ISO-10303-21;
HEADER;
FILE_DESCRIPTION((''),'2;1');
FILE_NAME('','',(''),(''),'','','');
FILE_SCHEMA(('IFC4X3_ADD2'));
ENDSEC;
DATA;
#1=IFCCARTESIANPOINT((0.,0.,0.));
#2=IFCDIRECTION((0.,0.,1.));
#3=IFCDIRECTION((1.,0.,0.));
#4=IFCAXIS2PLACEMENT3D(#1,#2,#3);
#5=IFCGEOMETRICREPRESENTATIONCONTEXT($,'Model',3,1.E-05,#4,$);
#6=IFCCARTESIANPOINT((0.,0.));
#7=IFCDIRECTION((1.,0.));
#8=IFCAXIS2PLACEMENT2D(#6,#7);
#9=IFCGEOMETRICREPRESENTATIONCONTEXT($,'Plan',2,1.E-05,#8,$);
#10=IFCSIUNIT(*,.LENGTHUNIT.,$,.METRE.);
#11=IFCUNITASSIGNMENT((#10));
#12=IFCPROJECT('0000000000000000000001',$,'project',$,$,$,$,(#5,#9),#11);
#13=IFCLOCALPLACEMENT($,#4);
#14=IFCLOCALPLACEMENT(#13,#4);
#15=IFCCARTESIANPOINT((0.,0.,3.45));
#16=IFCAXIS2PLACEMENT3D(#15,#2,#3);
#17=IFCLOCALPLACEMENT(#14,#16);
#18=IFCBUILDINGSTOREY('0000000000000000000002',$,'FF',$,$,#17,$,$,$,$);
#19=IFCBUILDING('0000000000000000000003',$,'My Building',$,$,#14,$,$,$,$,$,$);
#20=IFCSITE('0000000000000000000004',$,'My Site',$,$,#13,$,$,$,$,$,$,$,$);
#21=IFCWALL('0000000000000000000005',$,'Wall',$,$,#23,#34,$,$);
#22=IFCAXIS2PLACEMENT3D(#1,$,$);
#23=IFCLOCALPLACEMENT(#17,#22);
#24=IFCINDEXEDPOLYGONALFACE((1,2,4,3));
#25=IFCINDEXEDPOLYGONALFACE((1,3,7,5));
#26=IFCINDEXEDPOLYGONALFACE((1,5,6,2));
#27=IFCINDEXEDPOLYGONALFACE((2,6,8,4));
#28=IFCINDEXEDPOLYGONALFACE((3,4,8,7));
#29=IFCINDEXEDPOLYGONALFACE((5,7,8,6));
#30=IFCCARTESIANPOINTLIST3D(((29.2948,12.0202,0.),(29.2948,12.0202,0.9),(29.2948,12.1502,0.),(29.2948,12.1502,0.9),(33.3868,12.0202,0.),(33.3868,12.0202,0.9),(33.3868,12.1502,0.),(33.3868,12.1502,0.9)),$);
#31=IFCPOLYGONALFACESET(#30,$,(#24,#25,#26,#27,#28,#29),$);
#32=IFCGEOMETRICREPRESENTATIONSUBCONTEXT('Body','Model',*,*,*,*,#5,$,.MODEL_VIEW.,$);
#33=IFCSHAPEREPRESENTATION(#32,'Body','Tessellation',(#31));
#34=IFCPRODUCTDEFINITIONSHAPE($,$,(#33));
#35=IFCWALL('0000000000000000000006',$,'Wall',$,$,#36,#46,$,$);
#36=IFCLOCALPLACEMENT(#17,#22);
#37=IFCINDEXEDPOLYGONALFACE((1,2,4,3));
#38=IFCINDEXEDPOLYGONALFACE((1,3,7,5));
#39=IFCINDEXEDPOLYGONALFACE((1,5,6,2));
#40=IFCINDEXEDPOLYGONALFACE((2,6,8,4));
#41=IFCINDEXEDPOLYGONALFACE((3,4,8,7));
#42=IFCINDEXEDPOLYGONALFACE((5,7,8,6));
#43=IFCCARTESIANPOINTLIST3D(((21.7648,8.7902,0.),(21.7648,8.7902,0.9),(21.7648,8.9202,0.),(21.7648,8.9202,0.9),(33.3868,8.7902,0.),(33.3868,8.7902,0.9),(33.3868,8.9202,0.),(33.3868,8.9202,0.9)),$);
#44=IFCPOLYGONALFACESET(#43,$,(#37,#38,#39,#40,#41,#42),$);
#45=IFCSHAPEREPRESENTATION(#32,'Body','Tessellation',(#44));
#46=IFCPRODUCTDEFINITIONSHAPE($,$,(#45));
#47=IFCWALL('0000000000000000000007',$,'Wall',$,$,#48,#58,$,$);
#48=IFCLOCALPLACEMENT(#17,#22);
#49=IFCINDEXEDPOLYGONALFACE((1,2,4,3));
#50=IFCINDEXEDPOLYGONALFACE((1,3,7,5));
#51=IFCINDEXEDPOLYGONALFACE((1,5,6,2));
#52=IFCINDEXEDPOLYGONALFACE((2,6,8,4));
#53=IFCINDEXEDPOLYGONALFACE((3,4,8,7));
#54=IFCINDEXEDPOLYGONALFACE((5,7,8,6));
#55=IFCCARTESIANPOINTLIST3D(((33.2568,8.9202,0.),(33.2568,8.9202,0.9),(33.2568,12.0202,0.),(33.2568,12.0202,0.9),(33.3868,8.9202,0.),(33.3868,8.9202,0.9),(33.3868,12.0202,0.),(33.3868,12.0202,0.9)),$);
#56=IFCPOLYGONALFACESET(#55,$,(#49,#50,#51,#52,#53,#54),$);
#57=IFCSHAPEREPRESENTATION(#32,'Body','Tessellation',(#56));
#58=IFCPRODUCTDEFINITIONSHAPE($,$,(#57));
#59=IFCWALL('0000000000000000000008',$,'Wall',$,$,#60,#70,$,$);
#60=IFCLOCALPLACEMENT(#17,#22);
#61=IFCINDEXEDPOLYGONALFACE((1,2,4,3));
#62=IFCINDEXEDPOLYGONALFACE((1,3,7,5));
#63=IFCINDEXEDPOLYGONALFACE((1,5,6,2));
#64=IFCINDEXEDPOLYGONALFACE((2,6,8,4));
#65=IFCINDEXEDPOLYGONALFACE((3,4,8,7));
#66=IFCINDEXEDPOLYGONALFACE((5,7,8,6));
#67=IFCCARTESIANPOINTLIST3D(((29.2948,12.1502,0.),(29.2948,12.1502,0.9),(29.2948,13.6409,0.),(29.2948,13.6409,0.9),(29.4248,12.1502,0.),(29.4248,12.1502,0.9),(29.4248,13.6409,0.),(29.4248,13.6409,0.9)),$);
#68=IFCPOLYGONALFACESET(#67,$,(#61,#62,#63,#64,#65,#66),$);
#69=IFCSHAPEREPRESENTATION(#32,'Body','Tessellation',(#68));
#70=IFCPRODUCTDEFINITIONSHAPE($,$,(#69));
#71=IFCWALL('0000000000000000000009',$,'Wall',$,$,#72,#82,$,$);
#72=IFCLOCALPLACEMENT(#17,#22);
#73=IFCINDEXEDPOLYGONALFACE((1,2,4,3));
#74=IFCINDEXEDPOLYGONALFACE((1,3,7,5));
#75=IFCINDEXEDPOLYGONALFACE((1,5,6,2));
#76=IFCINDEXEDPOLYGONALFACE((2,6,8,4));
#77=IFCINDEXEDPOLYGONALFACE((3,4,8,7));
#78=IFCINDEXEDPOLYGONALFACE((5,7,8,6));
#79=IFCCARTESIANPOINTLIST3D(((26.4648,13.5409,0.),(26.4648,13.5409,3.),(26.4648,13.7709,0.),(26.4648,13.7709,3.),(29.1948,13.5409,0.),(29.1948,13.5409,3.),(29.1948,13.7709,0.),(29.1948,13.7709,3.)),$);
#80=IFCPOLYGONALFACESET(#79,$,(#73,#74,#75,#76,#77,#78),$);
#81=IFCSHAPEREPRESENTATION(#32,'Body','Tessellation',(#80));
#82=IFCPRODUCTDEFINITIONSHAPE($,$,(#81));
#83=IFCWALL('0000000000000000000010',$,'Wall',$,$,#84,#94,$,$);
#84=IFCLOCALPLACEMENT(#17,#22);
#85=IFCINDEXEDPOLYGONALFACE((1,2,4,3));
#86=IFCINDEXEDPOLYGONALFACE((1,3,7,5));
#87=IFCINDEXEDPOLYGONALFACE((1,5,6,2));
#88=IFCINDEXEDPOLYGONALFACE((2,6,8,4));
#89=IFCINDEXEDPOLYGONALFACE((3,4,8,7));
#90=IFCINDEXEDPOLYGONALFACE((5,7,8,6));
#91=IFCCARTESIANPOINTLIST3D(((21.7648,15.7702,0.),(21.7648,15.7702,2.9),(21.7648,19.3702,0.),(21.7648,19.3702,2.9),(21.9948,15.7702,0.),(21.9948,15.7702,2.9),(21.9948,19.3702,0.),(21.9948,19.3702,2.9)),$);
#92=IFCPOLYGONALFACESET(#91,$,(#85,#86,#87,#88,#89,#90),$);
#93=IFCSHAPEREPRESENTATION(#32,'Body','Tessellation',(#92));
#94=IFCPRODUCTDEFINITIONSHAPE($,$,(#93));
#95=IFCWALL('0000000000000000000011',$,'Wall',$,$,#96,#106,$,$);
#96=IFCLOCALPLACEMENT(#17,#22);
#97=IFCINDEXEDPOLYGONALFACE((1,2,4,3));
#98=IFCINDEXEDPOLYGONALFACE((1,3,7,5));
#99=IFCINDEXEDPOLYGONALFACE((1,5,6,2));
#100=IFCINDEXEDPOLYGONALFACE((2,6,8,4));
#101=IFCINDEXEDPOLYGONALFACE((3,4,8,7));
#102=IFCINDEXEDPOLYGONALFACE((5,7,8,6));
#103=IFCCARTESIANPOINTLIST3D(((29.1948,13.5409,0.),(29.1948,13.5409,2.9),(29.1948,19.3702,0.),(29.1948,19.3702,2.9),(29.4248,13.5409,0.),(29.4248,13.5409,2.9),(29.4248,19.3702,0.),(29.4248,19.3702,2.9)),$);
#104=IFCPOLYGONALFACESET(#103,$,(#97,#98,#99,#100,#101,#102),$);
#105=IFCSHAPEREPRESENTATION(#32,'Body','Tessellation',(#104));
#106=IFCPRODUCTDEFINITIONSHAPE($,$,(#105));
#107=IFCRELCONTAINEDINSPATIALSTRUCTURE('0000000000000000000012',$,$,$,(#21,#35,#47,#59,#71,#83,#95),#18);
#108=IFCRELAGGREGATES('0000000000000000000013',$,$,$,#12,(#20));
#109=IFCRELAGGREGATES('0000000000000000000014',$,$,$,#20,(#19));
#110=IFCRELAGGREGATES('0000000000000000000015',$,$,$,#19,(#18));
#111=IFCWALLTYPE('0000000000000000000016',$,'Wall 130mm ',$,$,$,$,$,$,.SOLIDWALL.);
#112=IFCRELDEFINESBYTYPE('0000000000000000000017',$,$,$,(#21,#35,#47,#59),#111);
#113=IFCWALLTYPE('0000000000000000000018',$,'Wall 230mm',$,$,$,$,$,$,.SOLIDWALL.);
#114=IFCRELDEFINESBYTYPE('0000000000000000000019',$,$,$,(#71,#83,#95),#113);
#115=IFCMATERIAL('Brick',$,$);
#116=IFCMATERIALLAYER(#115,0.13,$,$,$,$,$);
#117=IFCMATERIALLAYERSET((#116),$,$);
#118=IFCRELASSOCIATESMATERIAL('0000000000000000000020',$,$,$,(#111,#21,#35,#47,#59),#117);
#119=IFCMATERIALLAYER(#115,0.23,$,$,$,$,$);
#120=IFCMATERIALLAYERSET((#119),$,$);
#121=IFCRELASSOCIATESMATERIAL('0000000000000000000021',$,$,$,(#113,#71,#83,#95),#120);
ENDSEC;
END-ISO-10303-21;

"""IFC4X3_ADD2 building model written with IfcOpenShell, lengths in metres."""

from ifc_helpers import new_model, si_unit, frame, origin_with_axes, origin_2d_with_axis, place, context, subcontext, project, spatial, indexed_curve, outline, extrude, material, layer, layer_set, layer_usage, type_object, element, save


model = new_model("IFC4X3_ADD2")

# Units and contexts
model_context = context("Model", 3, precision=1e-05, world=origin_with_axes())
plan_context = context("Plan", 2, precision=1e-05, world=origin_2d_with_axis())
body_context_1 = subcontext(model_context, "Body", "Model", "MODEL_VIEW")
ifc_project = project(units=[si_unit("LENGTHUNIT", "METRE")], contexts=[model_context, plan_context])

# Site, building, storey
site_placement = place(None, origin_with_axes())
site = spatial("IfcSite", under=ifc_project, at=site_placement, Name="My Site")
building_placement = place(site_placement, origin_with_axes())
building = spatial("IfcBuilding", under=site, at=building_placement, Name="My Building")
storey_placement = place(building_placement, frame((0.0, 0.0, 3.45), z_axis=(0.0, 0.0, 1.0), x_axis=(1.0, 0.0, 0.0)))
storey = spatial("IfcBuildingStorey", under=building, at=storey_placement, Name="FF")

# Walls
ifc_material = material(Name="Brick")
ifc_layer_1 = layer(ifc_material, 0.13)
ifc_layer_set_1 = layer_set([ifc_layer_1])
ifc_layer_usage_1 = layer_usage(ifc_layer_set_1, "AXIS2", "POSITIVE", 0.0)
wall_type_1 = type_object("IfcWallType", Name="Wall 130mm ", PredefinedType="SOLIDWALL", material=ifc_layer_set_1)
wall_1_placement = place(storey_placement, frame((33.3868, 12.1502, 0.0), z_axis=(0.0, 0.0, 1.0), x_axis=(-1.0, 0.0, 0.0)))
element("IfcWall", 1, at=wall_1_placement, inside=storey, type_object=wall_type_1, material=ifc_layer_usage_1, Name="Wall", context=body_context_1, shape_type="SweptSolid", body=[
    extrude(outline(indexed_curve([(0.0, 0.0), (0.0, 0.13), (4.092, 0.13), (4.092, 0.0), (0.0, 0.0)], self_intersect=False)), origin_with_axes(), (0.0, 0.0, 1.0), 0.9),
])
ifc_layer_usage_2 = layer_usage(ifc_layer_set_1, "AXIS2", "POSITIVE", 0.0)
wall_2_placement = place(storey_placement, frame((33.3868, 8.9202, 0.0), z_axis=(0.0, 0.0, 1.0), x_axis=(-1.0, 0.0, 0.0)))
element("IfcWall", 2, at=wall_2_placement, inside=storey, type_object=wall_type_1, material=ifc_layer_usage_2, Name="Wall", context=body_context_1, shape_type="SweptSolid", body=[
    extrude(outline(indexed_curve([(0.0, 0.0), (0.0, 0.13), (11.622, 0.13), (11.622, 0.0), (0.0, 0.0)], self_intersect=False)), origin_with_axes(), (0.0, 0.0, 1.0), 0.9),
])
ifc_layer_usage_3 = layer_usage(ifc_layer_set_1, "AXIS2", "POSITIVE", 0.0)
wall_3_placement = place(storey_placement, frame((33.2568, 12.0202, 0.0), z_axis=(0.0, 0.0, 1.0), x_axis=(0.0, -1.0, 0.0)))
element("IfcWall", 3, at=wall_3_placement, inside=storey, type_object=wall_type_1, material=ifc_layer_usage_3, Name="Wall", context=body_context_1, shape_type="SweptSolid", body=[
    extrude(outline(indexed_curve([(0.0, 0.0), (0.0, 0.13), (3.1, 0.13), (3.1, 0.0), (0.0, 0.0)], self_intersect=False)), origin_with_axes(), (0.0, 0.0, 1.0), 0.9),
])
ifc_layer_usage_4 = layer_usage(ifc_layer_set_1, "AXIS2", "POSITIVE", 0.0)
wall_4_placement = place(storey_placement, frame((29.2948, 13.6409, 0.0), z_axis=(0.0, 0.0, 1.0), x_axis=(0.0, -1.0, 0.0)))
element("IfcWall", 4, at=wall_4_placement, inside=storey, type_object=wall_type_1, material=ifc_layer_usage_4, Name="Wall", context=body_context_1, shape_type="SweptSolid", body=[
    extrude(outline(indexed_curve([(0.0, 0.0), (0.0, 0.13), (1.4907, 0.13), (1.4907, 0.0), (0.0, 0.0)], self_intersect=False)), origin_with_axes(), (0.0, 0.0, 1.0), 0.9),
])
ifc_layer_2 = layer(ifc_material, 0.23)
ifc_layer_set_2 = layer_set([ifc_layer_2])
ifc_layer_usage_5 = layer_usage(ifc_layer_set_2, "AXIS2", "POSITIVE", 0.0)
wall_type_2 = type_object("IfcWallType", Name="Wall 230mm", PredefinedType="SOLIDWALL", material=ifc_layer_set_2)
wall_5_placement = place(storey_placement, frame((29.1948, 13.7709, 0.0), z_axis=(0.0, 0.0, 1.0), x_axis=(-1.0, 0.0, 0.0)))
element("IfcWall", 5, at=wall_5_placement, inside=storey, type_object=wall_type_2, material=ifc_layer_usage_5, Name="Wall", context=body_context_1, shape_type="SweptSolid", body=[
    extrude(outline(indexed_curve([(0.0, 0.0), (0.0, 0.23), (2.73, 0.23), (2.73, 0.0), (0.0, 0.0)], self_intersect=False)), origin_with_axes(), (0.0, 0.0, 1.0), 3.0),
])
ifc_layer_usage_6 = layer_usage(ifc_layer_set_2, "AXIS2", "POSITIVE", 0.0)
wall_6_placement = place(storey_placement, frame((21.9948, 15.7702, 0.0), z_axis=(0.0, 0.0, 1.0), x_axis=(0.000001, 1.0, 0.0)))
element("IfcWall", 6, at=wall_6_placement, inside=storey, type_object=wall_type_2, material=ifc_layer_usage_6, Name="Wall", context=body_context_1, shape_type="SweptSolid", body=[
    extrude(outline(indexed_curve([(0.0, 0.0), (0.0, 0.23), (3.6, 0.23), (3.6, 0.0), (0.0, 0.0)], self_intersect=False)), origin_with_axes(), (0.0, 0.0, 1.0), 2.9),
])
ifc_layer_usage_7 = layer_usage(ifc_layer_set_2, "AXIS2", "POSITIVE", 0.0)
wall_7_placement = place(storey_placement, frame((29.4248, 13.5409, 0.0), z_axis=(0.0, 0.0, 1.0), x_axis=(0.000001, 1.0, 0.0)))
element("IfcWall", 7, at=wall_7_placement, inside=storey, type_object=wall_type_2, material=ifc_layer_usage_7, Name="Wall", context=body_context_1, shape_type="SweptSolid", body=[
    extrude(outline(indexed_curve([(0.0, 0.0), (0.0, 0.23), (5.8293, 0.23), (5.8293, 0.0), (0.0, 0.0)], self_intersect=False)), origin_with_axes(), (0.0, 0.0, 1.0), 2.9),
])

save(model, "model.ifc")
